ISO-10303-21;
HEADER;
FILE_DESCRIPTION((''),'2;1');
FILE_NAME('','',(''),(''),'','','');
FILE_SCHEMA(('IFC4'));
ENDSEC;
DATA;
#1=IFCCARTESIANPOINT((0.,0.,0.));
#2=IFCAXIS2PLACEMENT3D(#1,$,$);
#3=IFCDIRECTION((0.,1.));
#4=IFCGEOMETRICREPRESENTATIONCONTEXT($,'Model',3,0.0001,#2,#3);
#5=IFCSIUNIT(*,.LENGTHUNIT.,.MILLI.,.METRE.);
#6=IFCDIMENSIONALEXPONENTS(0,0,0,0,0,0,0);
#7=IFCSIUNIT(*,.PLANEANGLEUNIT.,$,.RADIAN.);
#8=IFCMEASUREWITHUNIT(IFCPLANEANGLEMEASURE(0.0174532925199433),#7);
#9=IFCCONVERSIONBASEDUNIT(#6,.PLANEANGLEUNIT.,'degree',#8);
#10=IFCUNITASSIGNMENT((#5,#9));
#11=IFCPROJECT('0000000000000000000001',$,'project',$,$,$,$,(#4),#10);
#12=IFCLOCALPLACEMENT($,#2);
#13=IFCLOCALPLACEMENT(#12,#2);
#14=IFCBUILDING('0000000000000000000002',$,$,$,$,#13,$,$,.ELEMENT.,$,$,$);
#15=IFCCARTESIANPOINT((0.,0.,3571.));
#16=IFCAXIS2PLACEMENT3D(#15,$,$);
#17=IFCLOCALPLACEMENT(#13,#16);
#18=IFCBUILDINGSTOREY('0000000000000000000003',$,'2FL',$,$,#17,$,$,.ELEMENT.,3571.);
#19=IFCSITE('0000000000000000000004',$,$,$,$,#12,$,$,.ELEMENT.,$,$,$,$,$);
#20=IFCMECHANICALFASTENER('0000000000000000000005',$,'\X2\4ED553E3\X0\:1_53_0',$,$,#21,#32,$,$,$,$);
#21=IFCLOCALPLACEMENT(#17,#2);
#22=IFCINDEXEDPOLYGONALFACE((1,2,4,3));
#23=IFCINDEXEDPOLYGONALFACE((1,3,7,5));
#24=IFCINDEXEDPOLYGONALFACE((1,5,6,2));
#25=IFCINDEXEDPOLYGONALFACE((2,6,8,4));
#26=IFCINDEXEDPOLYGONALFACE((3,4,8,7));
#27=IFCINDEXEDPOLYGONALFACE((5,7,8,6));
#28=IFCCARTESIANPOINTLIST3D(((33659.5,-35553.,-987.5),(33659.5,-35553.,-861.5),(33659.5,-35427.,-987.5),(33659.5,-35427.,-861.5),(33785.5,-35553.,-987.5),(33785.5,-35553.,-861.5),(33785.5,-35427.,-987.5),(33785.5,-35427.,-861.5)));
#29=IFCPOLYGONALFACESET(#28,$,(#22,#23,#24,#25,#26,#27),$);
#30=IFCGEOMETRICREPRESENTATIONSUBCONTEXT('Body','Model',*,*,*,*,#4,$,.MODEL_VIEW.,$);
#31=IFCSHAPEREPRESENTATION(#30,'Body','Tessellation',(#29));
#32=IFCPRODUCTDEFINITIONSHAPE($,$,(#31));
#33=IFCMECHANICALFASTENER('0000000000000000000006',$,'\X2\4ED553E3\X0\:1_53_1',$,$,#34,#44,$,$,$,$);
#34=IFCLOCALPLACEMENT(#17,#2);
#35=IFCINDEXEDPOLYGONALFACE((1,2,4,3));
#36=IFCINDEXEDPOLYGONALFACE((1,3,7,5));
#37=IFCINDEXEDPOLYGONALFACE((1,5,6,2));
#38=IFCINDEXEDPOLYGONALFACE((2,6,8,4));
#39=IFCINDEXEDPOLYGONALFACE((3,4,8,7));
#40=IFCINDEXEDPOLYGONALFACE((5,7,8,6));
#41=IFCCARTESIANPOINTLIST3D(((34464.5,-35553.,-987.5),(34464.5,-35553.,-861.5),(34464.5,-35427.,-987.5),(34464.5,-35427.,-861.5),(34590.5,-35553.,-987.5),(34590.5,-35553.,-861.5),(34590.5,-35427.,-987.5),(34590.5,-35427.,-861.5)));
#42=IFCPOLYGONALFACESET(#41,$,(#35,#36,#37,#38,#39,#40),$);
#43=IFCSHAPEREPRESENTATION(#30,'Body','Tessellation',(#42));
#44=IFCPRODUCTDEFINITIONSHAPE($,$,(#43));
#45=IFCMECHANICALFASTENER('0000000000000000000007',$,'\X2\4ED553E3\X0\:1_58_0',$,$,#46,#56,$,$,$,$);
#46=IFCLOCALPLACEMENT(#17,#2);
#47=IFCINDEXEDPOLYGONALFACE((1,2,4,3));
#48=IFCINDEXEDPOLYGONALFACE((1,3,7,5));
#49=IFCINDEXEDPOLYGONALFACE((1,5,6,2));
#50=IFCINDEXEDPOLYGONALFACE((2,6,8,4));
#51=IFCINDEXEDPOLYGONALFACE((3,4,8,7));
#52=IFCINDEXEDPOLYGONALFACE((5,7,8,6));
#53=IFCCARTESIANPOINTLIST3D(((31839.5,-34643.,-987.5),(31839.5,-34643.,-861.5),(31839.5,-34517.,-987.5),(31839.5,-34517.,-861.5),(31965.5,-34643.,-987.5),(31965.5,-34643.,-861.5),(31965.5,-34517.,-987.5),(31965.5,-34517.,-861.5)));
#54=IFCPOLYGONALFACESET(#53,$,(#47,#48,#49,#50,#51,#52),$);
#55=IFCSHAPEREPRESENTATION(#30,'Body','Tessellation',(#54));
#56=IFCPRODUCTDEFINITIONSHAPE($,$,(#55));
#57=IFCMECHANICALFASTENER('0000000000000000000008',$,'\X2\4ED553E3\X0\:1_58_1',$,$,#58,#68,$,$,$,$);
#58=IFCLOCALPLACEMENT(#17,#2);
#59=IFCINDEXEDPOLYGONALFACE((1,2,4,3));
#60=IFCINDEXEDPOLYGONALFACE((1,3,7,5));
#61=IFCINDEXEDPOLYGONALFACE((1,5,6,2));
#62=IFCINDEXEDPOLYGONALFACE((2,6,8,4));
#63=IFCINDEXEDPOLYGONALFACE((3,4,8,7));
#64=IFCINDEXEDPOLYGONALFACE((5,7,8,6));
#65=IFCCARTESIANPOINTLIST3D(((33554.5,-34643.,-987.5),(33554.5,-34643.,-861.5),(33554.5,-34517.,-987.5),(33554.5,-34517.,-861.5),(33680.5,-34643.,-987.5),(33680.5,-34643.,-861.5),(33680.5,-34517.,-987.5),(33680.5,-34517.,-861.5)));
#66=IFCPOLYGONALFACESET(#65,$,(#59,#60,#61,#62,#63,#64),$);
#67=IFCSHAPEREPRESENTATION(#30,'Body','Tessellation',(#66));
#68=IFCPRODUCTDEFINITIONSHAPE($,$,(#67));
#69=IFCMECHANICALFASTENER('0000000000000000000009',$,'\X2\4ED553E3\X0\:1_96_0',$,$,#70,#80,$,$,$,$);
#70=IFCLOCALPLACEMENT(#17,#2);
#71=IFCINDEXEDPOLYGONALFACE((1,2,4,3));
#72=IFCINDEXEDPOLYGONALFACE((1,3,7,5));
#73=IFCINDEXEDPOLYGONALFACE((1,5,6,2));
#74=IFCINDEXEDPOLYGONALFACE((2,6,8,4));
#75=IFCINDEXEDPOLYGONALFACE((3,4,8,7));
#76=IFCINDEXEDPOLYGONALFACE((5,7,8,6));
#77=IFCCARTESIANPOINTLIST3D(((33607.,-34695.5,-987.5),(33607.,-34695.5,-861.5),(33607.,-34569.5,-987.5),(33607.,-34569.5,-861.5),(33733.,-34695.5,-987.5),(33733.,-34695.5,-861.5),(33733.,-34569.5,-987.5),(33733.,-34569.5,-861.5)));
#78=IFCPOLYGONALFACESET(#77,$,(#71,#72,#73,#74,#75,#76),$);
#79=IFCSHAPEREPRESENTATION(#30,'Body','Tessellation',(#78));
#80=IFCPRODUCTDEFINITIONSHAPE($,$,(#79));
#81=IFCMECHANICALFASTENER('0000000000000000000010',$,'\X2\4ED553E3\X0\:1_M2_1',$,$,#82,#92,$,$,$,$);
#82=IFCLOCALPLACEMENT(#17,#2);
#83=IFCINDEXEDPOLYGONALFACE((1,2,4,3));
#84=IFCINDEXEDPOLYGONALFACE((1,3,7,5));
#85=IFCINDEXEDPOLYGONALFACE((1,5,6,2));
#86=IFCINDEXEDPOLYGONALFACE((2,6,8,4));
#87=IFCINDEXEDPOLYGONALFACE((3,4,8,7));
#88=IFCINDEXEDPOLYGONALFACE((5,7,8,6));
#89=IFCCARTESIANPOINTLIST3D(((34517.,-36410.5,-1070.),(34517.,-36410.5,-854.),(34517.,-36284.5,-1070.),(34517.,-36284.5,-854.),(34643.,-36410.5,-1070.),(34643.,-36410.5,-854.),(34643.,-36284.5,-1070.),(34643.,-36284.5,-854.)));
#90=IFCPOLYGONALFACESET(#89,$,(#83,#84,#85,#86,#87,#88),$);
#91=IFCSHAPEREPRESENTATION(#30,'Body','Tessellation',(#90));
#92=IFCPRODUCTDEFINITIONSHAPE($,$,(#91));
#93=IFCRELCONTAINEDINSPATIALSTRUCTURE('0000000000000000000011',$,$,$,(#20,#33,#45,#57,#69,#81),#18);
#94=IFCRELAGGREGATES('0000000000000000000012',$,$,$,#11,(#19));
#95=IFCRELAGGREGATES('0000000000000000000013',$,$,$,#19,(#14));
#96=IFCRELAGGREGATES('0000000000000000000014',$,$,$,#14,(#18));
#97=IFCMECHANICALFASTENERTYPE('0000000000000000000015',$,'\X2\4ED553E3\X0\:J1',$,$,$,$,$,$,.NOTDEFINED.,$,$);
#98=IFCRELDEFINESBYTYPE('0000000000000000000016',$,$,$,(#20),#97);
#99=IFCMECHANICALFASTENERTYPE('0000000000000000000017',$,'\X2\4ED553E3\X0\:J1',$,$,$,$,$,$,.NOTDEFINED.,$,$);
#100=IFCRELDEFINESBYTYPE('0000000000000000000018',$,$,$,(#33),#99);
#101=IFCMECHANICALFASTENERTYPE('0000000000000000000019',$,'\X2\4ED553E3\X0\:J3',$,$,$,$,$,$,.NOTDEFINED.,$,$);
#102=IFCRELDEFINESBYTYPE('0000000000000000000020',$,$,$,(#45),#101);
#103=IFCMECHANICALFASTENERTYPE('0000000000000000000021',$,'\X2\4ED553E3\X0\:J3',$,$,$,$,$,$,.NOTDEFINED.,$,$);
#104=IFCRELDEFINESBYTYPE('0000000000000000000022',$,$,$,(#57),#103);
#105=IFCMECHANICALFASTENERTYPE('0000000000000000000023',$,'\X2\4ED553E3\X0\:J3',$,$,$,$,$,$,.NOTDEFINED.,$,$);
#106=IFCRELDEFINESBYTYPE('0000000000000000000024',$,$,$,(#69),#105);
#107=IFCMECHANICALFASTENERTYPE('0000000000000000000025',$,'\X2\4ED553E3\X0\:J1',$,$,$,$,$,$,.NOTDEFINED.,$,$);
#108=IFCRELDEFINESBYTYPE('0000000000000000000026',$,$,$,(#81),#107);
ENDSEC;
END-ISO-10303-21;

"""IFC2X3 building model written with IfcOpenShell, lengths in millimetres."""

from ifc_helpers import new_model, entity, si_unit, converted_unit, direction, frame, origin, origin_with_axes, origin_2d, place, context, subcontext, project, spatial, rectangle, extrude, type_object, element, save


model = new_model("IFC2X3")

# Units and contexts
model_context = context("Model", 3, precision=0.0001, world=origin(), true_north=direction((0.0, 1.0)))
body_context = subcontext(model_context, "Body", "Model", "MODEL_VIEW")
ifc_project = project(units=[si_unit("LENGTHUNIT", "METRE", prefix="MILLI"), converted_unit("PLANEANGLEUNIT", "degree", entity("IfcPlaneAngleMeasure", 0.0174532925199433), si_unit("PLANEANGLEUNIT", "RADIAN"), dimensions=[0, 0, 0, 0, 0, 0, 0])], contexts=[model_context])

# Site, building, storey
site_placement = place(None, origin())
site = spatial("IfcSite", under=ifc_project, at=site_placement, CompositionType="ELEMENT")
building_placement = place(site_placement, origin())
building = spatial("IfcBuilding", under=site, at=building_placement, CompositionType="ELEMENT")
storey_placement = place(building_placement, frame((0.0, 0.0, 3571.0)))
storey = spatial("IfcBuildingStorey", under=building, at=storey_placement, Name="2FL", CompositionType="ELEMENT", Elevation=3571.0)

# Mechanical fasteners
mechanical_fastener_type_1 = type_object("IfcMechanicalFastenerType", Name="仕口:J1")
mechanical_fastener_1_placement = place(storey_placement, frame((33722.5, -35490.0, -987.5)))
element("IfcMechanicalFastener", 1, at=mechanical_fastener_1_placement, inside=storey, type_object=mechanical_fastener_type_1, Name="仕口:1_53_0", context=body_context, shape_type="SweptSolid", body=[
    extrude(rectangle(XDim=126.0, YDim=126.0, at=origin_2d()), origin_with_axes(), (0.0, 0.0, 1.0), 126.0),
])
mechanical_fastener_type_2 = type_object("IfcMechanicalFastenerType", Name="仕口:J1")
mechanical_fastener_2_placement = place(storey_placement, frame((34527.5, -35490.0, -987.5)))
element("IfcMechanicalFastener", 2, at=mechanical_fastener_2_placement, inside=storey, type_object=mechanical_fastener_type_2, Name="仕口:1_53_1", context=body_context, shape_type="SweptSolid", body=[
    extrude(rectangle(XDim=126.0, YDim=126.0, at=origin_2d()), origin_with_axes(), (0.0, 0.0, 1.0), 126.0),
])
mechanical_fastener_type_3 = type_object("IfcMechanicalFastenerType", Name="仕口:J3")
mechanical_fastener_3_placement = place(storey_placement, frame((31902.5, -34580.0, -987.5)))
element("IfcMechanicalFastener", 3, at=mechanical_fastener_3_placement, inside=storey, type_object=mechanical_fastener_type_3, Name="仕口:1_58_0", context=body_context, shape_type="SweptSolid", body=[
    extrude(rectangle(XDim=126.0, YDim=126.0, at=origin_2d()), origin_with_axes(), (0.0, 0.0, 1.0), 126.0),
])
mechanical_fastener_type_4 = type_object("IfcMechanicalFastenerType", Name="仕口:J3")
mechanical_fastener_4_placement = place(storey_placement, frame((33617.5, -34580.0, -987.5)))
element("IfcMechanicalFastener", 4, at=mechanical_fastener_4_placement, inside=storey, type_object=mechanical_fastener_type_4, Name="仕口:1_58_1", context=body_context, shape_type="SweptSolid", body=[
    extrude(rectangle(XDim=126.0, YDim=126.0, at=origin_2d()), origin_with_axes(), (0.0, 0.0, 1.0), 126.0),
])
mechanical_fastener_type_5 = type_object("IfcMechanicalFastenerType", Name="仕口:J3")
mechanical_fastener_5_placement = place(storey_placement, frame((33670.0, -34632.5, -987.5)))
element("IfcMechanicalFastener", 5, at=mechanical_fastener_5_placement, inside=storey, type_object=mechanical_fastener_type_5, Name="仕口:1_96_0", context=body_context, shape_type="SweptSolid", body=[
    extrude(rectangle(XDim=126.0, YDim=126.0, at=origin_2d()), origin_with_axes(), (0.0, 0.0, 1.0), 126.0),
])
mechanical_fastener_type_6 = type_object("IfcMechanicalFastenerType", Name="仕口:J1")
mechanical_fastener_6_placement = place(storey_placement, frame((34580.0, -36347.5, -1070.0)))
element("IfcMechanicalFastener", 6, at=mechanical_fastener_6_placement, inside=storey, type_object=mechanical_fastener_type_6, Name="仕口:1_M2_1", context=body_context, shape_type="SweptSolid", body=[
    extrude(rectangle(XDim=126.0, YDim=126.0, at=origin_2d()), origin_with_axes(), (0.0, 0.0, 1.0), 216.0),
])

save(model, "model.ifc")
